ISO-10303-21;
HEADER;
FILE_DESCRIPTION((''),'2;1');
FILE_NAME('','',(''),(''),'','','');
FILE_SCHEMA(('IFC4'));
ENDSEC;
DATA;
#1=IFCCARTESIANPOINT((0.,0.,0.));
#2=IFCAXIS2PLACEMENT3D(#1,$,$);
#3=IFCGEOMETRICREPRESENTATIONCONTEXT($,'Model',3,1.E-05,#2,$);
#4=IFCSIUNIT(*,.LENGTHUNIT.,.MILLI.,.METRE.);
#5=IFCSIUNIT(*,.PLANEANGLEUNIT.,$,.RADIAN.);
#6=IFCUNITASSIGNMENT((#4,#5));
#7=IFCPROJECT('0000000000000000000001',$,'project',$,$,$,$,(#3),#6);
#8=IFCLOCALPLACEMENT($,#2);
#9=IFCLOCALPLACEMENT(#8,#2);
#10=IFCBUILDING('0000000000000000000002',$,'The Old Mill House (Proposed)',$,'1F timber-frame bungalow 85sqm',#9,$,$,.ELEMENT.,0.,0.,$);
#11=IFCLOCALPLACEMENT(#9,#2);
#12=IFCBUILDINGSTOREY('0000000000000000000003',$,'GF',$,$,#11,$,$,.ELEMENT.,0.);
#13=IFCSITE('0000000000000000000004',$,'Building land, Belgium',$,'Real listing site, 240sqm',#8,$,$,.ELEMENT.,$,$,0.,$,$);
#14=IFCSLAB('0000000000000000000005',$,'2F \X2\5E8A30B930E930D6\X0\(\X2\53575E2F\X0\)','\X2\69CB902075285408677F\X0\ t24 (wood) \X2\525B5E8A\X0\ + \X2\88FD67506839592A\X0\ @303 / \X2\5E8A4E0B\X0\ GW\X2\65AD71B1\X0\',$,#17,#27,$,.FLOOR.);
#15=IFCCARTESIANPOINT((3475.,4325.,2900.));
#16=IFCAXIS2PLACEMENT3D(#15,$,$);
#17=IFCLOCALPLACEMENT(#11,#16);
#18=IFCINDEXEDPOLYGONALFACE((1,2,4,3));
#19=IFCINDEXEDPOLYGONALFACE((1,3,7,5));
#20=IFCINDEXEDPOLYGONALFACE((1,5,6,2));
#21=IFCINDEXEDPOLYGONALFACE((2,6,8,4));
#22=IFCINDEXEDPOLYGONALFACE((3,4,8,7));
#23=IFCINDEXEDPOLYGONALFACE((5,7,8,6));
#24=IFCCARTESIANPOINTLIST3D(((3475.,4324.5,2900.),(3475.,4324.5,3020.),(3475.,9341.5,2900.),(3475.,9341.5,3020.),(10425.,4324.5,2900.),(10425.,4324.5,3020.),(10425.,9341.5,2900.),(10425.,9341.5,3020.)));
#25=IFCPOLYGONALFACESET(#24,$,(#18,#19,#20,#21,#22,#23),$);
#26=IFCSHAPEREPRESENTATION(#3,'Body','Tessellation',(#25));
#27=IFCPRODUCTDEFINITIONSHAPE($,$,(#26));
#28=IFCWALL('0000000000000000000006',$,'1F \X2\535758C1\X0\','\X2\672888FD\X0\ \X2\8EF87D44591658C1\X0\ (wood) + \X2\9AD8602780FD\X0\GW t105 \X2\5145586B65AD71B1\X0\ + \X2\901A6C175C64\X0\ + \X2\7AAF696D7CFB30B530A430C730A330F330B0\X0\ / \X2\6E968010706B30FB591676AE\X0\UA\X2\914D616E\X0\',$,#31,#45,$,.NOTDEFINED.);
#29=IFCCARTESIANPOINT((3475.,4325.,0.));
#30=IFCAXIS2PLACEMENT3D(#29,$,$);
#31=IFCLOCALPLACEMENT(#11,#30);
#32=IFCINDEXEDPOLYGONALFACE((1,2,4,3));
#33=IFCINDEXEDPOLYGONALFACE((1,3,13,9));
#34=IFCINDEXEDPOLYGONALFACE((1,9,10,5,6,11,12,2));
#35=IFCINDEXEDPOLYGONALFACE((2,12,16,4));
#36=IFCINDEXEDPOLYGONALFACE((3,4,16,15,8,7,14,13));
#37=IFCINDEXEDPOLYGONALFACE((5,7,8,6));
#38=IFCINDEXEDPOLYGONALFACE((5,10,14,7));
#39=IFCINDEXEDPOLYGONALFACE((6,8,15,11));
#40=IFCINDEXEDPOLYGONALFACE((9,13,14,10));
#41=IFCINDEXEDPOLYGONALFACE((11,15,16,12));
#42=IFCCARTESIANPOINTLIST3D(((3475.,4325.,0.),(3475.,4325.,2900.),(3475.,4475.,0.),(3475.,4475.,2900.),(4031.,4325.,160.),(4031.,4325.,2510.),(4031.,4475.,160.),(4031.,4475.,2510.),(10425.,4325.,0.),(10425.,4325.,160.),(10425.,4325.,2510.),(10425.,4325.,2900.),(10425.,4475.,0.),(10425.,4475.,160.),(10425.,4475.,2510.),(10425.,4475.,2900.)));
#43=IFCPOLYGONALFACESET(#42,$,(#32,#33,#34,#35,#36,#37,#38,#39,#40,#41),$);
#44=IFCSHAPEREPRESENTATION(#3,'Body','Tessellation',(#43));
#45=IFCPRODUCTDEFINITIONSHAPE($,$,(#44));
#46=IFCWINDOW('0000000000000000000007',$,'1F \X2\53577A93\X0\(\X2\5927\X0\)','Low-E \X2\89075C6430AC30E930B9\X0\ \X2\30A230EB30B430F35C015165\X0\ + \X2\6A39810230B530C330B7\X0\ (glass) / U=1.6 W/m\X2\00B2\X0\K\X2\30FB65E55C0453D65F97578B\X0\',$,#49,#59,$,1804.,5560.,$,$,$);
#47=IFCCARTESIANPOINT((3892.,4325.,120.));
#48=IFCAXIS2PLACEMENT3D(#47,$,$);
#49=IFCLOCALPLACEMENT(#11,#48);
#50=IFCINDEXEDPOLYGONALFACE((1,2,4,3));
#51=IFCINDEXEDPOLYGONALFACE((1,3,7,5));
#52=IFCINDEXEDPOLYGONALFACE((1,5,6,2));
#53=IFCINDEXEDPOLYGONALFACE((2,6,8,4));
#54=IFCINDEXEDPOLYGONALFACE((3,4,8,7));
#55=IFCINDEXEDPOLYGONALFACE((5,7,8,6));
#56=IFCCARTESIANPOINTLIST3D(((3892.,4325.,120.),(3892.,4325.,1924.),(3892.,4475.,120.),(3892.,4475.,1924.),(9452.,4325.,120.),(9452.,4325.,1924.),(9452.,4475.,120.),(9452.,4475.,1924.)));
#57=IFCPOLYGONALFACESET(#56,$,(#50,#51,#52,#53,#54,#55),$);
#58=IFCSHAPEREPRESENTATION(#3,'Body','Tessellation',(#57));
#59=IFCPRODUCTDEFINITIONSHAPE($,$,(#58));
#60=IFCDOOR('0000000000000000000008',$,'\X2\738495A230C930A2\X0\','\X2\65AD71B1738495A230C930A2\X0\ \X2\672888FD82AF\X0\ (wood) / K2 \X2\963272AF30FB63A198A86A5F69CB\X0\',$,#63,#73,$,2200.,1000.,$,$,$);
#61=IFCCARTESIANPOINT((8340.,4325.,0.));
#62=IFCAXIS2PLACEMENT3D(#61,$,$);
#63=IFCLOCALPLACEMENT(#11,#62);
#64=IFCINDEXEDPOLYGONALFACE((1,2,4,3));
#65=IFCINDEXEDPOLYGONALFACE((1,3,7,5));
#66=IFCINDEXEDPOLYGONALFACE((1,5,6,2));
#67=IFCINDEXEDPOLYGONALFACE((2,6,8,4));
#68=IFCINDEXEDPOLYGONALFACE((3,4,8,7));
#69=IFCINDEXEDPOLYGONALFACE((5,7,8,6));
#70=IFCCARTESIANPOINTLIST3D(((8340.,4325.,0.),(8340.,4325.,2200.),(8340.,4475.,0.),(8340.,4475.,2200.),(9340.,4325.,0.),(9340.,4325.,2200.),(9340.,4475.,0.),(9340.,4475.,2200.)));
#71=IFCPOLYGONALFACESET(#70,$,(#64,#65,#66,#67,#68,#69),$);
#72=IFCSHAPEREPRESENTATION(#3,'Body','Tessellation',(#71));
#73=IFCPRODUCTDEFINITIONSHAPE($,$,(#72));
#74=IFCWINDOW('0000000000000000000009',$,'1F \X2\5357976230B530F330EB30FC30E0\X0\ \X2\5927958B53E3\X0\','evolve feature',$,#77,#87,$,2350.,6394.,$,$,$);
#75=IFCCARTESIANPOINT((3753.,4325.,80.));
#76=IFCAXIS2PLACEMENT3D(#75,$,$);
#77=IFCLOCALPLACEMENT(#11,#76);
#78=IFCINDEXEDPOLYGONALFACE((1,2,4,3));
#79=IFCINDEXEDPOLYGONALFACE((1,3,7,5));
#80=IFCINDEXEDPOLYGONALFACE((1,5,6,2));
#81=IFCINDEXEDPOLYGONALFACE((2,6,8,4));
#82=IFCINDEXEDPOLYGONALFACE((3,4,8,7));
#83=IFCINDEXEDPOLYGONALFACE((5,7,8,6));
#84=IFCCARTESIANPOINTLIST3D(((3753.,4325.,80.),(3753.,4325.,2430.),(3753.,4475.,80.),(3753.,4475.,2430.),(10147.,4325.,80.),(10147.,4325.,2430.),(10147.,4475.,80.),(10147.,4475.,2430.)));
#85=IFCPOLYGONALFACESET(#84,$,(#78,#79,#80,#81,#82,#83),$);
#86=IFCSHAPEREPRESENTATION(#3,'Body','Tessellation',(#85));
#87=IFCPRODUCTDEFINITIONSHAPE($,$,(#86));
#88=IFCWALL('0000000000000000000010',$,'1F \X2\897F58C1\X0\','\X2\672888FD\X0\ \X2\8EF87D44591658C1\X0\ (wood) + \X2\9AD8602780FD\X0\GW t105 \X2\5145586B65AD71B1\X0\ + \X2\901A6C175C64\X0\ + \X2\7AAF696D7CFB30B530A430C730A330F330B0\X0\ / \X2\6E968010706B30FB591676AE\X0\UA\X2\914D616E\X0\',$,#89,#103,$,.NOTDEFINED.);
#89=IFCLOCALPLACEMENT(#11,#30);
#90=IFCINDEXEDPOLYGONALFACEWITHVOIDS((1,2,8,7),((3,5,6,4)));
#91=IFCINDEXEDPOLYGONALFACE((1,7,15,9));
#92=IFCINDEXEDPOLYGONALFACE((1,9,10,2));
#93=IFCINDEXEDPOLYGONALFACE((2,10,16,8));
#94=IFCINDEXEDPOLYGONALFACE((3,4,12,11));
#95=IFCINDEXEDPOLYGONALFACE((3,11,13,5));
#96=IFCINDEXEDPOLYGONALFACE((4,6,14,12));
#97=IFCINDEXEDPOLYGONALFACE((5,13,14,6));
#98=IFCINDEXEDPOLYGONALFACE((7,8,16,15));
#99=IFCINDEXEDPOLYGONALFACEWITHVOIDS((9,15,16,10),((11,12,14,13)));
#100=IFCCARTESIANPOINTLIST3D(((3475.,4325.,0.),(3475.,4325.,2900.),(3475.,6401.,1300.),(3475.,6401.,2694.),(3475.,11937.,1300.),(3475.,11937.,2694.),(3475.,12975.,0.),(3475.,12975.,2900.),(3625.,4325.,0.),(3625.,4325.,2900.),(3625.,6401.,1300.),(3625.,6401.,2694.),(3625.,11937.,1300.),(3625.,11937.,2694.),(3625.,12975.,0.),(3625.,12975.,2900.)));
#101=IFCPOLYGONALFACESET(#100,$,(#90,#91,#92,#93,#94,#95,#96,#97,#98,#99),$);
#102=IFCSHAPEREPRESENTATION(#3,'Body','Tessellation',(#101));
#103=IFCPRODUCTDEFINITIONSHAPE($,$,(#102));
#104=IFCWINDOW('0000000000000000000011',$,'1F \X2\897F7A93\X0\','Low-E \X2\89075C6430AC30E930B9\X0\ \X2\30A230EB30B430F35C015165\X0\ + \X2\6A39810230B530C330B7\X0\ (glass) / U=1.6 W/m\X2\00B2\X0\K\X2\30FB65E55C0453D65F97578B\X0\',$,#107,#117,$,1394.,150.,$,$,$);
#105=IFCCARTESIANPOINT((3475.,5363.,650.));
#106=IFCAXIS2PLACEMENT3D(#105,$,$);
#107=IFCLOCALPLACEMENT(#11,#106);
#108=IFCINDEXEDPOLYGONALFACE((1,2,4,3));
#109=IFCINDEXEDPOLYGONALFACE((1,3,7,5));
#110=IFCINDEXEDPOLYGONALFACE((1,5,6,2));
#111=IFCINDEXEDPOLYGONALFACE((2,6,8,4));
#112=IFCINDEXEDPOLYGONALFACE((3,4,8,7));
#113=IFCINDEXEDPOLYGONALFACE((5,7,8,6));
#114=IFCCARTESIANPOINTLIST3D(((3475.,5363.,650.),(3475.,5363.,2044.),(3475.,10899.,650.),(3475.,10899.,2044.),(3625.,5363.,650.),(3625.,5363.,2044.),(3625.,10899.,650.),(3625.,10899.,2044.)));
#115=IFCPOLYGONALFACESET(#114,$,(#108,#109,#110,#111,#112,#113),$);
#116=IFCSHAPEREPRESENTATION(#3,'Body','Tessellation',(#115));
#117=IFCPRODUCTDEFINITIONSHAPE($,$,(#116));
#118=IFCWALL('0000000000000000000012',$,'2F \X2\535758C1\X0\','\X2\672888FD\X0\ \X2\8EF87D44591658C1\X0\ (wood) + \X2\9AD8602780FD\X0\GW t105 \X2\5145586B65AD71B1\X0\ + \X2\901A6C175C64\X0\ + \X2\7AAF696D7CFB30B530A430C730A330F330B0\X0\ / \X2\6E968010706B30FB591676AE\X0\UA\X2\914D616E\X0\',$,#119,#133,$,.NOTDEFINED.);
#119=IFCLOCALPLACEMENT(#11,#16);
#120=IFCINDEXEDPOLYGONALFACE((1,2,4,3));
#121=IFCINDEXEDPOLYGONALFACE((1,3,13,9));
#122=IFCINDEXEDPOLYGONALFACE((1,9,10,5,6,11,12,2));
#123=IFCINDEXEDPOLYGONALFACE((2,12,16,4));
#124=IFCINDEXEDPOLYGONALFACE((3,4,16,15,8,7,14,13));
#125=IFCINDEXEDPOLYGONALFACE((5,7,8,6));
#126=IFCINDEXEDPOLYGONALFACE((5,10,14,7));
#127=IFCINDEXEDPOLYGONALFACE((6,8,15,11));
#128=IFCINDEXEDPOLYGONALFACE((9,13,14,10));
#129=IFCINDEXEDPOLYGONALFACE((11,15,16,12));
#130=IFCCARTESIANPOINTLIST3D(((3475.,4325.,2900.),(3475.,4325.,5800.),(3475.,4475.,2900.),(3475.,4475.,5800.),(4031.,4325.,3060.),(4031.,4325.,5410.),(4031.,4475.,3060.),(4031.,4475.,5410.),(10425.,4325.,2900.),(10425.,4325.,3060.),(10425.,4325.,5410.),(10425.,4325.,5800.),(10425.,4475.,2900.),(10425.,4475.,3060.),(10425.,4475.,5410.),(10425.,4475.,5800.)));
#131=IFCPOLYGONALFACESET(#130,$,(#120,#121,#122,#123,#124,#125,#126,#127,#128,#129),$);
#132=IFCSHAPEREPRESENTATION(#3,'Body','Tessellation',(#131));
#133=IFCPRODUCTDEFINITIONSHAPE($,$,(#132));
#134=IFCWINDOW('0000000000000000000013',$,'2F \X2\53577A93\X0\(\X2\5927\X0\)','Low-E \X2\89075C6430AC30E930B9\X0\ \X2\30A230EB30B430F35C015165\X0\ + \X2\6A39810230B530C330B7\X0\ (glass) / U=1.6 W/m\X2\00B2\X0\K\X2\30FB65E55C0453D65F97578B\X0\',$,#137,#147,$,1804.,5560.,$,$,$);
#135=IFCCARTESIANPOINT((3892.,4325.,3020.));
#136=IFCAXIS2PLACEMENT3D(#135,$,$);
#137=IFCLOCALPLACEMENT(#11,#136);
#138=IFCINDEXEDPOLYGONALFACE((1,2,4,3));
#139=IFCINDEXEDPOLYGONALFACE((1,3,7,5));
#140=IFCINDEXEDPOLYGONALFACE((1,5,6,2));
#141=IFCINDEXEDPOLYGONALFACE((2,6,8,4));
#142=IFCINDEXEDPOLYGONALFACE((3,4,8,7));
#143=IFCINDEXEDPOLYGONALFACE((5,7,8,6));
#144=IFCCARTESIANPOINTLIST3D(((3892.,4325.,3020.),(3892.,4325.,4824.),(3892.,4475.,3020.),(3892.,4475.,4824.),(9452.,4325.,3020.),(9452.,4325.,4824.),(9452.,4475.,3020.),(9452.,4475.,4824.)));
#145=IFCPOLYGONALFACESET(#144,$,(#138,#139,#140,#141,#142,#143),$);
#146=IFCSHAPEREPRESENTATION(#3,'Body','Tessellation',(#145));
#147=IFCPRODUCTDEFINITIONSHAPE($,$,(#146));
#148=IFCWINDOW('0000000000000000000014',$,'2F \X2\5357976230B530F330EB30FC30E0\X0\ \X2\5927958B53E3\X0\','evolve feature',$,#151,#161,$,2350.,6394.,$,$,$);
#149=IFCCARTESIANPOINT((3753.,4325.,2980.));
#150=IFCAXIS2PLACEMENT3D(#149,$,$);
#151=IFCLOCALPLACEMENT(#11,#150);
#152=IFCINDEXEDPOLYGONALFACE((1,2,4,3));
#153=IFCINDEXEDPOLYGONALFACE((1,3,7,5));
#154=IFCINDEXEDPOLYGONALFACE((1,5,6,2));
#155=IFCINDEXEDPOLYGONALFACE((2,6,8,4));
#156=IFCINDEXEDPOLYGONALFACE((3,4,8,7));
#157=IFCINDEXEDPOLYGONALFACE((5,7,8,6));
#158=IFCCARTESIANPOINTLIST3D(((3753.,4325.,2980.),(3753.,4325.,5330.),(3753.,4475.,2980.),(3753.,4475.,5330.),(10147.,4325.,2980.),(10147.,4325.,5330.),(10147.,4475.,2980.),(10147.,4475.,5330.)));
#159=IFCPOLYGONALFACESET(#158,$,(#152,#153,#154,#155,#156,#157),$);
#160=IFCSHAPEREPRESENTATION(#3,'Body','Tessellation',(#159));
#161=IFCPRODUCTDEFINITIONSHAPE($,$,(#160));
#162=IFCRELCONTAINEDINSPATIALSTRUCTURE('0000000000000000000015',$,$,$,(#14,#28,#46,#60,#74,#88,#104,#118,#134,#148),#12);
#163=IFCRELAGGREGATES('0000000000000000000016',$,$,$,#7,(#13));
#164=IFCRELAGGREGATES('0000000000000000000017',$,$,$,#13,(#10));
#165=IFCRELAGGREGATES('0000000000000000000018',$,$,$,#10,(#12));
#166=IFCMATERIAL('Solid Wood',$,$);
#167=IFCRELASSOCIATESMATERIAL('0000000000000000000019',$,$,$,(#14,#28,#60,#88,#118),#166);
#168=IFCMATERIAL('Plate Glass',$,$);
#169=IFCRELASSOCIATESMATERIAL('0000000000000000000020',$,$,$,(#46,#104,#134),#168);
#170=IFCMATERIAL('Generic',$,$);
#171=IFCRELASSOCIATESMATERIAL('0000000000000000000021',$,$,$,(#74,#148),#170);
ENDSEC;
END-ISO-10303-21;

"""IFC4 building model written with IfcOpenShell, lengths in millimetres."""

from ifc_helpers import new_model, si_unit, frame, frame_2d, origin, place, context, project, spatial, rectangle, extrude, material, element, fill, save


model = new_model("IFC4")

# Units and contexts
model_context = context("Model", 3, precision=1e-05, world=origin())
ifc_project = project(units=[si_unit("LENGTHUNIT", "METRE", prefix="MILLI"), si_unit("PLANEANGLEUNIT", "RADIAN")], contexts=[model_context])

# Site, building, storey
site_placement = place(None, origin())
site = spatial("IfcSite", under=ifc_project, at=site_placement, Name="Building land, Belgium", ObjectType="Real listing site, 240sqm", CompositionType="ELEMENT", RefElevation=0.0)
building_placement = place(site_placement, origin())
building = spatial("IfcBuilding", under=site, at=building_placement, Name="The Old Mill House (Proposed)", ObjectType="1F timber-frame bungalow 85sqm", CompositionType="ELEMENT", ElevationOfRefHeight=0.0, ElevationOfTerrain=0.0)
storey_placement = place(building_placement, origin())
storey = spatial("IfcBuildingStorey", under=building, at=storey_placement, Name="GF", CompositionType="ELEMENT", Elevation=0.0)

# Slab
ifc_material_1 = material(Name="Solid Wood")
slab_1_placement = place(storey_placement, frame((3475.0, 4325.0, 2900.0)))
element("IfcSlab", 1, at=slab_1_placement, inside=storey, material=ifc_material_1, Name="2F 床スラブ(南帯)", Description="構造用合板 t24 (wood) 剛床 + 製材根太 @303 / 床下 GW断熱", PredefinedType="FLOOR", context=model_context, shape_type="SweptSolid", body=[
    extrude(rectangle(XDim=6950.0, YDim=5017.0, at=frame_2d((3475.0, 2508.0))), frame((3475.0, 4325.0, 2900.0)), (0.0, 0.0, 1.0), 120.0),
])
ifc_material_2 = material(Name="Generic")

# Wall, openings, windows, door
wall_1_placement = place(storey_placement, frame((3475.0, 4325.0, 0.0)))
wall_1 = element("IfcWall", 2, at=wall_1_placement, inside=storey, material=ifc_material_1, Name="1F 南壁", Description="木製 軸組外壁 (wood) + 高性能GW t105 充填断熱 + 通気層 + 窯業系サイディング / 準耐火・外皮UA配慮", PredefinedType="NOTDEFINED", context=model_context, shape_type="SweptSolid", body=[
    extrude(rectangle(XDim=6950.0, YDim=150.0, at=frame_2d((3475.0, 75.0))), frame((3475.0, 4325.0, 0.0)), (0.0, 0.0, 1.0), 2900.0),
])
opening_1_placement = place(storey_placement, frame((3892.0, 4325.0, 120.0)))
opening_1 = element("IfcOpeningElement", 3, at=opening_1_placement, cuts=wall_1, PredefinedType="NOTDEFINED", context=model_context, shape_type="SweptSolid", body=[
    extrude(rectangle(XDim=5560.0, YDim=150.0, at=frame_2d((2780.0, 75.0))), frame((3892.0, 4325.0, 120.0)), (0.0, 0.0, 1.0), 1804.0),
])
opening_2_placement = place(storey_placement, frame((8340.0, 4325.0, 0.0)))
opening_2 = element("IfcOpeningElement", 4, at=opening_2_placement, cuts=wall_1, PredefinedType="NOTDEFINED", context=model_context, shape_type="SweptSolid", body=[
    extrude(rectangle(XDim=1000.0, YDim=150.0, at=frame_2d((500.0, 75.0))), frame((8340.0, 4325.0, 0.0)), (0.0, 0.0, 1.0), 2200.0),
])
opening_3_placement = place(storey_placement, frame((3753.0, 4325.0, 80.0)))
opening_3 = element("IfcOpeningElement", 5, at=opening_3_placement, cuts=wall_1, PredefinedType="NOTDEFINED", context=model_context, shape_type="SweptSolid", body=[
    extrude(rectangle(XDim=6394.0, YDim=150.0, at=frame_2d((3197.0, 75.0))), frame((3753.0, 4325.0, 80.0)), (0.0, 0.0, 1.0), 2350.0),
])
ifc_material_3 = material(Name="Plate Glass")
window_1_placement = place(storey_placement, frame((3892.0, 4325.0, 120.0)))
window_1 = element("IfcWindow", 6, at=window_1_placement, inside=storey, material=ifc_material_3, Name="1F 南窓(大)", Description="Low-E 複層ガラス アルゴン封入 + 樹脂サッシ (glass) / U=1.6 W/m²K・日射取得型", OverallHeight=1804.0, OverallWidth=5560.0, context=model_context, shape_type="SweptSolid", body=[
    extrude(rectangle(XDim=5560.0, YDim=150.0, at=frame_2d((2780.0, 75.0))), frame((3892.0, 4325.0, 120.0)), (0.0, 0.0, 1.0), 1804.0),
])
fill(opening_1, window_1)
door_placement = place(storey_placement, frame((8340.0, 4325.0, 0.0)))
door = element("IfcDoor", 7, at=door_placement, inside=storey, material=ifc_material_1, Name="玄関ドア", Description="断熱玄関ドア 木製芯 (wood) / K2 防犯・採風機構", OverallHeight=2200.0, OverallWidth=1000.0, context=model_context, shape_type="SweptSolid", body=[
    extrude(rectangle(XDim=1000.0, YDim=150.0, at=frame_2d((500.0, 75.0))), frame((8340.0, 4325.0, 0.0)), (0.0, 0.0, 1.0), 2200.0),
])
fill(opening_2, door)
window_2_placement = place(storey_placement, frame((3753.0, 4325.0, 80.0)))
window_2 = element("IfcWindow", 8, at=window_2_placement, inside=storey, material=ifc_material_2, Name="1F 南面サンルーム 大開口", Description="evolve feature", OverallHeight=2350.0, OverallWidth=6394.0, context=model_context, shape_type="SweptSolid", body=[
    extrude(rectangle(XDim=6394.0, YDim=150.0, at=frame_2d((3197.0, 75.0))), frame((3753.0, 4325.0, 80.0)), (0.0, 0.0, 1.0), 2350.0),
])
fill(opening_3, window_2)

# Wall, opening, window
wall_2_placement = place(storey_placement, frame((3475.0, 4325.0, 0.0)))
wall_2 = element("IfcWall", 9, at=wall_2_placement, inside=storey, material=ifc_material_1, Name="1F 西壁", Description="木製 軸組外壁 (wood) + 高性能GW t105 充填断熱 + 通気層 + 窯業系サイディング / 準耐火・外皮UA配慮", PredefinedType="NOTDEFINED", context=model_context, shape_type="SweptSolid", body=[
    extrude(rectangle(XDim=150.0, YDim=8650.0, at=frame_2d((75.0, 4325.0))), frame((3475.0, 4325.0, 0.0)), (0.0, 0.0, 1.0), 2900.0),
])
opening_4_placement = place(storey_placement, frame((3475.0, 5363.0, 650.0)))
opening_4 = element("IfcOpeningElement", 10, at=opening_4_placement, cuts=wall_2, PredefinedType="NOTDEFINED", context=model_context, shape_type="SweptSolid", body=[
    extrude(rectangle(XDim=150.0, YDim=5536.0, at=frame_2d((75.0, 2768.0))), frame((3475.0, 5363.0, 650.0)), (0.0, 0.0, 1.0), 1394.0),
])
window_3_placement = place(storey_placement, frame((3475.0, 5363.0, 650.0)))
window_3 = element("IfcWindow", 11, at=window_3_placement, inside=storey, material=ifc_material_3, Name="1F 西窓", Description="Low-E 複層ガラス アルゴン封入 + 樹脂サッシ (glass) / U=1.6 W/m²K・日射取得型", OverallHeight=1394.0, OverallWidth=150.0, context=model_context, shape_type="SweptSolid", body=[
    extrude(rectangle(XDim=150.0, YDim=5536.0, at=frame_2d((75.0, 2768.0))), frame((3475.0, 5363.0, 650.0)), (0.0, 0.0, 1.0), 1394.0),
])
fill(opening_4, window_3)

# Wall, openings, windows
wall_3_placement = place(storey_placement, frame((3475.0, 4325.0, 2900.0)))
wall_3 = element("IfcWall", 12, at=wall_3_placement, inside=storey, material=ifc_material_1, Name="2F 南壁", Description="木製 軸組外壁 (wood) + 高性能GW t105 充填断熱 + 通気層 + 窯業系サイディング / 準耐火・外皮UA配慮", PredefinedType="NOTDEFINED", context=model_context, shape_type="SweptSolid", body=[
    extrude(rectangle(XDim=6950.0, YDim=150.0, at=frame_2d((3475.0, 75.0))), frame((3475.0, 4325.0, 2900.0)), (0.0, 0.0, 1.0), 2900.0),
])
opening_5_placement = place(storey_placement, frame((3892.0, 4325.0, 3020.0)))
opening_5 = element("IfcOpeningElement", 13, at=opening_5_placement, cuts=wall_3, PredefinedType="NOTDEFINED", context=model_context, shape_type="SweptSolid", body=[
    extrude(rectangle(XDim=5560.0, YDim=150.0, at=frame_2d((2780.0, 75.0))), frame((3892.0, 4325.0, 3020.0)), (0.0, 0.0, 1.0), 1804.0),
])
opening_6_placement = place(storey_placement, frame((3753.0, 4325.0, 2980.0)))
opening_6 = element("IfcOpeningElement", 14, at=opening_6_placement, cuts=wall_3, PredefinedType="NOTDEFINED", context=model_context, shape_type="SweptSolid", body=[
    extrude(rectangle(XDim=6394.0, YDim=150.0, at=frame_2d((3197.0, 75.0))), frame((3753.0, 4325.0, 2980.0)), (0.0, 0.0, 1.0), 2350.0),
])
window_4_placement = place(storey_placement, frame((3892.0, 4325.0, 3020.0)))
window_4 = element("IfcWindow", 15, at=window_4_placement, inside=storey, material=ifc_material_3, Name="2F 南窓(大)", Description="Low-E 複層ガラス アルゴン封入 + 樹脂サッシ (glass) / U=1.6 W/m²K・日射取得型", OverallHeight=1804.0, OverallWidth=5560.0, context=model_context, shape_type="SweptSolid", body=[
    extrude(rectangle(XDim=5560.0, YDim=150.0, at=frame_2d((2780.0, 75.0))), frame((3892.0, 4325.0, 3020.0)), (0.0, 0.0, 1.0), 1804.0),
])
fill(opening_5, window_4)
window_5_placement = place(storey_placement, frame((3753.0, 4325.0, 2980.0)))
window_5 = element("IfcWindow", 16, at=window_5_placement, inside=storey, material=ifc_material_2, Name="2F 南面サンルーム 大開口", Description="evolve feature", OverallHeight=2350.0, OverallWidth=6394.0, context=model_context, shape_type="SweptSolid", body=[
    extrude(rectangle(XDim=6394.0, YDim=150.0, at=frame_2d((3197.0, 75.0))), frame((3753.0, 4325.0, 2980.0)), (0.0, 0.0, 1.0), 2350.0),
])
fill(opening_6, window_5)

save(model, "model.ifc")
